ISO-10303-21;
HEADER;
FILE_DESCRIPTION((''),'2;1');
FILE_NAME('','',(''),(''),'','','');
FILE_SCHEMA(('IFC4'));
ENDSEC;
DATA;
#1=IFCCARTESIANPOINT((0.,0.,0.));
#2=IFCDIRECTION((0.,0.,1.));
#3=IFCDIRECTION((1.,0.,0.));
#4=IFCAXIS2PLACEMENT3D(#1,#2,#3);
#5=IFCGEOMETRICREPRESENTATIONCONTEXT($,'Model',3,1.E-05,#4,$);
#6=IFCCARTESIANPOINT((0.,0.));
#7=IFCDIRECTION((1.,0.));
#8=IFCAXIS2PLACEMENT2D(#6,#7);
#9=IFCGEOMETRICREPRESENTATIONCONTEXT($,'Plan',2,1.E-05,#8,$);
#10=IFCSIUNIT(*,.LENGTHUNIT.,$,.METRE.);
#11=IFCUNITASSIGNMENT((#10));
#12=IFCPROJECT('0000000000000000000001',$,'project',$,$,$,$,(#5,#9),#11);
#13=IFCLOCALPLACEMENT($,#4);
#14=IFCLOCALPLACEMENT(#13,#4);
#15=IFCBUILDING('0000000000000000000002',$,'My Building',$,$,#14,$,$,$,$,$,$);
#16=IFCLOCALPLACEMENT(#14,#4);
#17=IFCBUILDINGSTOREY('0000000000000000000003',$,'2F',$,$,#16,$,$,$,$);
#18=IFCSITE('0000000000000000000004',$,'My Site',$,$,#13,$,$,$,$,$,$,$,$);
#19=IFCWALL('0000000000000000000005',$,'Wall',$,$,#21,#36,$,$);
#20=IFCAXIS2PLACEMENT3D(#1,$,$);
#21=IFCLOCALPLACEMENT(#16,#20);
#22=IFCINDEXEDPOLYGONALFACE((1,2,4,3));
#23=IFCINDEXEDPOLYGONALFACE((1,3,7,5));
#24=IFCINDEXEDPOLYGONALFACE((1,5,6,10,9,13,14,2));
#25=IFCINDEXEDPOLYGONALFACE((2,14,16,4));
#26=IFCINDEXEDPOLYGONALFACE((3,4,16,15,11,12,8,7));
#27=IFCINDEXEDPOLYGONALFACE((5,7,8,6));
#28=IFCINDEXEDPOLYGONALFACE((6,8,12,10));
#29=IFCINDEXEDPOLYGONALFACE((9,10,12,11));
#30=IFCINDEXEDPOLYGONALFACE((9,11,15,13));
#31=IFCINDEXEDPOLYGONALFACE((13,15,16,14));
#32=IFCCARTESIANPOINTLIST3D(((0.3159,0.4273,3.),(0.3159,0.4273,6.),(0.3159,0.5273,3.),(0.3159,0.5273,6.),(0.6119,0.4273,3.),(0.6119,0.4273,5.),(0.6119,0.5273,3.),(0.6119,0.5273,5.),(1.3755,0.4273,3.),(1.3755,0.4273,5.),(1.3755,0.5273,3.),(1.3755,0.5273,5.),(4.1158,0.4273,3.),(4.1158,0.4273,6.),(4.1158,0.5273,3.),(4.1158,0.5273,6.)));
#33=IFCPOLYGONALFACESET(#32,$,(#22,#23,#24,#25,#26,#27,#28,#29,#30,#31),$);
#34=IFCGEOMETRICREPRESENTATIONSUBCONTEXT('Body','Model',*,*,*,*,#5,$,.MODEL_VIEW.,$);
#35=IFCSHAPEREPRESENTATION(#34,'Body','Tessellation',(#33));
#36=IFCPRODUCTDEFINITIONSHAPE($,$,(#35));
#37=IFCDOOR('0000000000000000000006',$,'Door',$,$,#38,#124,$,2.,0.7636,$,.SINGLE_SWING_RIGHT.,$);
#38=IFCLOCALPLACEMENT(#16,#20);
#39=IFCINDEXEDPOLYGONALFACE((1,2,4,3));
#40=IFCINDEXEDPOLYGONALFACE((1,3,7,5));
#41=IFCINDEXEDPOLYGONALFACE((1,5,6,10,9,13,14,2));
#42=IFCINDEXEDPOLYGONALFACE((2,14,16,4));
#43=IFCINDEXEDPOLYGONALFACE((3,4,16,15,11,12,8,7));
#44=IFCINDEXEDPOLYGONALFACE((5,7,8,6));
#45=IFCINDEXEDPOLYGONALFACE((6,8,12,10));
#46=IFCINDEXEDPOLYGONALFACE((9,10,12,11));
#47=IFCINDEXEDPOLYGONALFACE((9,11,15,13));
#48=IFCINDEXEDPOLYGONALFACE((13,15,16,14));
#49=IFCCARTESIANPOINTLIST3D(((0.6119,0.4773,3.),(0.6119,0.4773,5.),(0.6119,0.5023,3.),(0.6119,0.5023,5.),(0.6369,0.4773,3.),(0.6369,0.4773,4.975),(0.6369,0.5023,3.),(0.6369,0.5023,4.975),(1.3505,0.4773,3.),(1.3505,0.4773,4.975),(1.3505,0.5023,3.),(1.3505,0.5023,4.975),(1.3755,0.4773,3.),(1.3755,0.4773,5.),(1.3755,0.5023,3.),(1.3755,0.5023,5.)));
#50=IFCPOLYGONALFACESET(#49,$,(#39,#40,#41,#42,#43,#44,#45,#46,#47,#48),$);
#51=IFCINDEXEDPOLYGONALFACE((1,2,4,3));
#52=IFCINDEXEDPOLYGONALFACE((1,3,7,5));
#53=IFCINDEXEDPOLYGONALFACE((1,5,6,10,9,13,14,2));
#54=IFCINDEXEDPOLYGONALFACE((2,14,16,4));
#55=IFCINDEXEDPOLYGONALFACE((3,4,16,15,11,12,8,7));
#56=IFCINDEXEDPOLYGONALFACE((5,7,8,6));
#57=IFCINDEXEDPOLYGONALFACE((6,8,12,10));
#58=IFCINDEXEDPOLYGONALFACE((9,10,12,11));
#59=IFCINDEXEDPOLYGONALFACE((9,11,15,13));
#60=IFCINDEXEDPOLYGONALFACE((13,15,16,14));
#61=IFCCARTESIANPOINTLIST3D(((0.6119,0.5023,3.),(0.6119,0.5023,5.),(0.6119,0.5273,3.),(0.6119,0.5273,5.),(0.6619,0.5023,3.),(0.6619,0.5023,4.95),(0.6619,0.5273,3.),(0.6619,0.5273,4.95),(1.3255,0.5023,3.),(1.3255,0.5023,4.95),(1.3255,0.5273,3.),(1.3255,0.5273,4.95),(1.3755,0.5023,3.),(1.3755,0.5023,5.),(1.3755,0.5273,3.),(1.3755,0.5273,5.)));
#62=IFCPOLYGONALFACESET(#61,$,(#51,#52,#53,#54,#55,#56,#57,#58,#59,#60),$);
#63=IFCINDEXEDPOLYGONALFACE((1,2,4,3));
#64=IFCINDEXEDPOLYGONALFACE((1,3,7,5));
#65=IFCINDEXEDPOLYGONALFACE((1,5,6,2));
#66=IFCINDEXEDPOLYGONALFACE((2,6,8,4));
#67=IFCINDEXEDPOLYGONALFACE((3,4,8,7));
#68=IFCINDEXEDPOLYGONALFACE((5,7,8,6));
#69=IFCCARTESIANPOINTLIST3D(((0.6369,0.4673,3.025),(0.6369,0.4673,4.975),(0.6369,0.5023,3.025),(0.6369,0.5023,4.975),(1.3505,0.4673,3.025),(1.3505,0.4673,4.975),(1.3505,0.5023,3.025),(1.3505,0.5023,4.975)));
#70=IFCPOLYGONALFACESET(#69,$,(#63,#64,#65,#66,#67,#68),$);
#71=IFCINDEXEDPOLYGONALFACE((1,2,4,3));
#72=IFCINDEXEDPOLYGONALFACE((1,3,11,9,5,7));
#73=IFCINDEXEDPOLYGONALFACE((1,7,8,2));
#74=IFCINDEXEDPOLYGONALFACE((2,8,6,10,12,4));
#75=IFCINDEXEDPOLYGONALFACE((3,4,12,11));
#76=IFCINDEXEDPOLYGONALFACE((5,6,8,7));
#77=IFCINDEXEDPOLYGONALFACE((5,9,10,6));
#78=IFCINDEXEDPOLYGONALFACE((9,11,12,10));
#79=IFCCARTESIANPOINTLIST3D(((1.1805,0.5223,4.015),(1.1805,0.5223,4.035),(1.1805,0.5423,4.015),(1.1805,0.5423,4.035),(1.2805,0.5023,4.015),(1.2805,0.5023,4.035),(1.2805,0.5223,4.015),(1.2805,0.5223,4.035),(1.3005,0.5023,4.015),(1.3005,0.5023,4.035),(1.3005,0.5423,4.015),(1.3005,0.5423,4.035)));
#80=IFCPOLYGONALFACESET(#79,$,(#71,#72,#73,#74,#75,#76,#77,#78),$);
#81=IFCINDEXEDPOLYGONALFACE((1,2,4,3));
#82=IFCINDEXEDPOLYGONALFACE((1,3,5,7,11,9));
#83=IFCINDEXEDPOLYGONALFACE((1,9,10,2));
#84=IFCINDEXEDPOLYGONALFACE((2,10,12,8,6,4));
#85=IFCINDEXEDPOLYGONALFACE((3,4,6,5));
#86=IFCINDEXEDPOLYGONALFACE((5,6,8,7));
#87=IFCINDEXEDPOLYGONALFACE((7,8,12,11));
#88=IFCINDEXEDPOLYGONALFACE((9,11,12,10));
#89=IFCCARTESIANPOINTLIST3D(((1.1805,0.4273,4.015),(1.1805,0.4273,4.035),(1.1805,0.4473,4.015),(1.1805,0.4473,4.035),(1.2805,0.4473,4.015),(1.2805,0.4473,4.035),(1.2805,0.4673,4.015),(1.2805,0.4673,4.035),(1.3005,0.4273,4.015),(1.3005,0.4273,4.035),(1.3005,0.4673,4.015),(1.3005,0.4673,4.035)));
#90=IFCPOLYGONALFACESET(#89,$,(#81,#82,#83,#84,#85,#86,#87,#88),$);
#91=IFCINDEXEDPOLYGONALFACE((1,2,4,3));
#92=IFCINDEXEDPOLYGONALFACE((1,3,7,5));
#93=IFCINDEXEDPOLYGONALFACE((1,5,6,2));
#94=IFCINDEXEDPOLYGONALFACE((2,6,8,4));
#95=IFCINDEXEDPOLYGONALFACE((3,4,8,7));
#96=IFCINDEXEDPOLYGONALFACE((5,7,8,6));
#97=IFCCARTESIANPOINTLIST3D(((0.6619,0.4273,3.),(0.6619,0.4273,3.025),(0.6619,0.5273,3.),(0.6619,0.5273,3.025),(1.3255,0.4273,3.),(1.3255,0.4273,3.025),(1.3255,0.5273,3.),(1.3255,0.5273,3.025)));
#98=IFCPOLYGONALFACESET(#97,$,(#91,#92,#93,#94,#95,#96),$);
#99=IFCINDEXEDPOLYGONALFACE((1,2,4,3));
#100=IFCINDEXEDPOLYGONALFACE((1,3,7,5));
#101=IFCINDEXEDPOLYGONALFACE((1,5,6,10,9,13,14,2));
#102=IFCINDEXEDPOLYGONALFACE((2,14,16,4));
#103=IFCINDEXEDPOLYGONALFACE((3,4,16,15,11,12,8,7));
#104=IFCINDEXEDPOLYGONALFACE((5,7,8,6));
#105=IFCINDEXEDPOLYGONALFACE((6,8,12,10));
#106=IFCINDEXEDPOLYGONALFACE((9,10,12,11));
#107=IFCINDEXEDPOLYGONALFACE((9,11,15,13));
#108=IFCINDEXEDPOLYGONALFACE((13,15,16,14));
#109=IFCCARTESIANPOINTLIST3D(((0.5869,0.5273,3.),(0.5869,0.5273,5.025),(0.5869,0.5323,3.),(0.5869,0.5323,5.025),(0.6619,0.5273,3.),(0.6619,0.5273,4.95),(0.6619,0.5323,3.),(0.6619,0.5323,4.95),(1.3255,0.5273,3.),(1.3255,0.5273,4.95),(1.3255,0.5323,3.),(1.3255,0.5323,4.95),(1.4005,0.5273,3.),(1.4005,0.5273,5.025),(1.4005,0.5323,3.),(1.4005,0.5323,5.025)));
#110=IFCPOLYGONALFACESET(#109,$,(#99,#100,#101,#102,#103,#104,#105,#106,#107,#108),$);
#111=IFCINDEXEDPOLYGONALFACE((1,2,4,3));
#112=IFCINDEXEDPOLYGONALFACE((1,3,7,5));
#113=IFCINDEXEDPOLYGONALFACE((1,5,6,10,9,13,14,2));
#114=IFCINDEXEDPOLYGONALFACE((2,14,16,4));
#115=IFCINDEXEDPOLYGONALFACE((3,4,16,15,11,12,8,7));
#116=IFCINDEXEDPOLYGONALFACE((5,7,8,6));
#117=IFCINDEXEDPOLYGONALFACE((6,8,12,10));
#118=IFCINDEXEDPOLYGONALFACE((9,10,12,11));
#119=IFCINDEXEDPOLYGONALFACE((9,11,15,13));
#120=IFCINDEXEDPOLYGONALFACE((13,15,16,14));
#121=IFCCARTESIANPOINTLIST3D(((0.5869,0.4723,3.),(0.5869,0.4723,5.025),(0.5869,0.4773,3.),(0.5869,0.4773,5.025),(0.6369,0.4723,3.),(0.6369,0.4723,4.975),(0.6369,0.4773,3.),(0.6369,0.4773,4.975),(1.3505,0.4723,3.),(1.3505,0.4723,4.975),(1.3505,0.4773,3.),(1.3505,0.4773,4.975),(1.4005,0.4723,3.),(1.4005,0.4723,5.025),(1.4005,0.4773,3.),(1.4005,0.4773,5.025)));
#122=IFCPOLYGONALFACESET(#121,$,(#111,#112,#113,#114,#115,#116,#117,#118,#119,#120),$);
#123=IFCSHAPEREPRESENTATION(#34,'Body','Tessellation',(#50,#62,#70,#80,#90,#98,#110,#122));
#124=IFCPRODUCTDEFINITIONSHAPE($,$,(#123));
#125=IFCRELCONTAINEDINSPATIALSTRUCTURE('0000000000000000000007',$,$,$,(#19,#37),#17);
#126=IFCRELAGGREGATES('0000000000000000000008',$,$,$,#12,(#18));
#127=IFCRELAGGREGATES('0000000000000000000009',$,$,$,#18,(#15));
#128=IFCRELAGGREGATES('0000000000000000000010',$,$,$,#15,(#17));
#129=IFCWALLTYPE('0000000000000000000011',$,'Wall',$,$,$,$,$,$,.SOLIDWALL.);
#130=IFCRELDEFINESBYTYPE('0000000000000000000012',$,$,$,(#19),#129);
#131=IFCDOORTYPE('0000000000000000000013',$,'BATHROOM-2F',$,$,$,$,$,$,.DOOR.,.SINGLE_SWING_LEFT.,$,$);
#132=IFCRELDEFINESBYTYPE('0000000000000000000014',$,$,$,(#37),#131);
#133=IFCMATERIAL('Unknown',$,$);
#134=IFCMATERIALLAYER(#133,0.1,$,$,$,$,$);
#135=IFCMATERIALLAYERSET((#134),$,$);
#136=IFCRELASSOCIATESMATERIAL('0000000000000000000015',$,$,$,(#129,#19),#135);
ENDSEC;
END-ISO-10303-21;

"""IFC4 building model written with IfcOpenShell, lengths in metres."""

from ifc_helpers import new_model, entity, si_unit, frame, origin_with_axes, origin_2d_with_axis, place, context, subcontext, project, spatial, line, indexed_curve, outline, extrude, shape, source, transform, mapped, material, layer, layer_set, layer_usage, type_object, type_shapes, element, fill, save


model = new_model("IFC4")

# Units and contexts
model_context = context("Model", 3, precision=1e-05, world=origin_with_axes())
plan_context = context("Plan", 2, precision=1e-05, world=origin_2d_with_axis())
body_context_1 = subcontext(model_context, "Body", "Model", "MODEL_VIEW")
body_context_2 = subcontext(plan_context, "Body", "Plan", "PLAN_VIEW")
ifc_project = project(units=[si_unit("LENGTHUNIT", "METRE")], contexts=[model_context, plan_context])

# Site, building, storey
site_placement = place(None, origin_with_axes())
site = spatial("IfcSite", under=ifc_project, at=site_placement, Name="My Site")
building_placement = place(site_placement, origin_with_axes())
building = spatial("IfcBuilding", under=site, at=building_placement, Name="My Building")
storey_placement = place(building_placement, origin_with_axes())
storey = spatial("IfcBuildingStorey", under=building, at=storey_placement, Name="2F")

# Shared definitions
ifc_material_1 = material(Name="Unknown")

# Shared definitions
ifc_layer_1 = layer(ifc_material_1, 0.1)
ifc_layer_set_1 = layer_set([ifc_layer_1])
wall_type = type_object("IfcWallType", Name="Wall", PredefinedType="SOLIDWALL", material=ifc_layer_set_1)

# Wall, opening, door
ifc_layer_usage_1 = layer_usage(ifc_layer_set_1, "AXIS2", "POSITIVE", 0.0)
wall_1_placement = place(storey_placement, frame((0.3159, 0.4273, 3.0), z_axis=(0.0, 0.0, 1.0), x_axis=(1.0, 0.0, 0.0)))
wall_1 = element("IfcWall", 1, at=wall_1_placement, inside=storey, type_object=wall_type, material=ifc_layer_usage_1, Name="Wall", context=body_context_1, shape_type="SweptSolid", body=[
    extrude(outline(indexed_curve([(0.0, 0.0), (0.0, 0.1), (3.8, 0.1), (3.8, 0.0)], segments=[line(1, 2, 3, 4, 1)])), origin_with_axes(), (0.0, 0.0, 1.0), 3.0),
])
shared_shape_1 = source(origin_with_axes(), body_context_1, "Body", "SweptSolid", [
    extrude(outline(indexed_curve([(0.0, 0.0), (0.7636, 0.0), (0.7636, 2.0), (0.0, 2.0)], segments=[line(1, 2, 3, 4, 1)])), frame((0.0, -0.6, 0.0), z_axis=(0.0, -1.0, 0.0), x_axis=(1.0, 0.0, 0.0)), (0.0, 0.0, -1.0), 1.2),
])
opening_1_placement = place(wall_1_placement, frame((1.0596, 0.1, 0.0), z_axis=(0.0, 0.0, 1.0), x_axis=(-1.0, 0.0, 0.0)))
opening_1 = element("IfcOpeningElement", 2, at=opening_1_placement, cuts=wall_1, PredefinedType="OPENING", context=body_context_1, shape_type="MappedRepresentation", body=[
    mapped(shared_shape_1, transform((0.0, 0.0, 0.0), x_axis=(1.0, 0.0, 0.0), y_axis=(0.0, 1.0, 0.0), z_axis=(0.0, 0.0, 1.0), scale=1.0)),
])
door_type_1 = type_object("IfcDoorType", Name="BATHROOM-2F", OperationType="SINGLE_SWING_LEFT", PredefinedType="DOOR")
shared_shape_2 = source(origin_with_axes(), body_context_1, "Body", "SweptSolid", [
    extrude(outline(indexed_curve([(0.0, 0.0), (0.0, 2.0), (0.7636, 2.0), (0.7636, 0.0), (0.7386, 0.0), (0.7386, 1.975), (0.025, 1.975), (0.025, 0.0)], segments=[line(1, 2, 3, 4, 5, 6, 7, 8, 1)])), frame((0.0, 0.025, 0.0), z_axis=(0.0, -1.0, 0.0), x_axis=(1.0, 0.0, 0.0)), (0.0, 0.0, -1.0), 0.025),
    extrude(outline(indexed_curve([(0.0, 0.0), (0.0, 2.0), (0.7636, 2.0), (0.7636, 0.0), (0.7136, 0.0), (0.7136, 1.95), (0.05, 1.95), (0.05, 0.0)], segments=[line(1, 2, 3, 4, 5, 6, 7, 8, 1)])), frame((0.0, 0.0, 0.0), z_axis=(0.0, -1.0, 0.0), x_axis=(1.0, 0.0, 0.0)), (0.0, 0.0, -1.0), 0.025),
    extrude(outline(indexed_curve([(0.0, 0.0), (0.7136, 0.0), (0.7136, 0.035), (0.0, 0.035)], segments=[line(1, 2, 3, 4, 1)])), frame((0.025, 0.025, 0.025), z_axis=(0.0, 0.0, 1.0), x_axis=(1.0, 0.0, 0.0)), (0.0, 0.0, 1.0), 1.95),
    extrude(outline(indexed_curve([(0.0, 0.0), (0.0, -0.04), (0.12, -0.04), (0.12, -0.02), (0.02, -0.02), (0.02, 0.0)], segments=[line(1, 2, 3, 4, 5, 6, 1)])), frame((0.075, 0.025, 1.015), z_axis=(0.0, 0.0, 1.0), x_axis=(1.0, 0.0, 0.0)), (0.0, 0.0, 1.0), 0.02),
    extrude(outline(indexed_curve([(0.0, 0.0), (0.0, 0.04), (0.12, 0.04), (0.12, 0.02), (0.02, 0.02), (0.02, 0.0)], segments=[line(1, 2, 3, 4, 5, 6, 1)])), frame((0.075, 0.06, 1.015), z_axis=(0.0, 0.0, 1.0), x_axis=(1.0, 0.0, 0.0)), (0.0, 0.0, 1.0), 0.02),
    extrude(outline(indexed_curve([(0.0, 0.0), (0.6636, 0.0), (0.6636, 0.1), (0.0, 0.1)], segments=[line(1, 2, 3, 4, 1)])), frame((0.05, 0.0, 0.0), z_axis=(0.0, 0.0, 1.0), x_axis=(1.0, 0.0, 0.0)), (0.0, 0.0, 1.0), 0.025),
    extrude(outline(indexed_curve([(0.0, 0.0), (0.0, 2.025), (0.8136, 2.025), (0.8136, 0.0), (0.7386, 0.0), (0.7386, 1.95), (0.075, 1.95), (0.075, 0.0)], segments=[line(1, 2, 3, 4, 5, 6, 7, 8, 1)])), frame((-0.025, -0.005, 0.0), z_axis=(0.0, -1.0, 0.0), x_axis=(1.0, 0.0, 0.0)), (0.0, 0.0, -1.0), 0.005),
    extrude(outline(indexed_curve([(0.0, 0.0), (0.0, 2.025), (0.8136, 2.025), (0.8136, 0.0), (0.7636, 0.0), (0.7636, 1.975), (0.05, 1.975), (0.05, 0.0)], segments=[line(1, 2, 3, 4, 5, 6, 7, 8, 1)])), frame((-0.025, 0.05, 0.0), z_axis=(0.0, -1.0, 0.0), x_axis=(1.0, 0.0, 0.0)), (0.0, 0.0, -1.0), 0.005),
])
shared_shape_3 = source(origin_with_axes(), body_context_2, "Body", "Curve2D", [
    entity("IfcIndexedPolyCurve", entity("IfcCartesianPointList2D", [[0.0, 0.0], [0.0, 0.05], [0.025, 0.05], [0.025, 0.025], [0.05, 0.025], [0.05, 0.0]]), [entity("IfcLineIndex", [1, 2, 3, 4, 5, 6, 1])]),
    entity("IfcIndexedPolyCurve", entity("IfcCartesianPointList2D", [[0.7636, 0.0], [0.7636, 0.05], [0.7386, 0.05], [0.7386, 0.025], [0.7136, 0.025], [0.7136, 0.0]]), [entity("IfcLineIndex", [1, 2, 3, 4, 5, 6, 1])]),
    entity("IfcTrimmedCurve", entity("IfcEllipse", entity("IfcAxis2Placement2D", entity("IfcCartesianPoint", [0.7036, 0.05]), entity("IfcDirection", [1.0, 0.0])), 0.6786, 0.7136), [entity("IfcCartesianPoint", [0.7036, 0.7636])], [entity("IfcCartesianPoint", [0.025, 0.05])], True, "CARTESIAN"),
    entity("IfcIndexedPolyCurve", entity("IfcCartesianPointList2D", [[0.7386, 0.05], [0.7036, 0.05], [0.7036, 0.7636], [0.7386, 0.7636]]), [entity("IfcLineIndex", [1, 2, 3, 4, 1])]),
])
type_shapes(door_type_1, [shared_shape_2, shared_shape_3])
door_1_placement = place(opening_1_placement, frame((0.0, 0.0, 0.0), z_axis=(0.0, 0.0, 1.0), x_axis=(1.0, 0.0, 0.0)))
door_1 = element("IfcDoor", 3, at=door_1_placement, inside=storey, type_object=door_type_1, Name="Door", OperationType="SINGLE_SWING_RIGHT", OverallHeight=2.0, OverallWidth=0.7636, shapes=[
    shape(body_context_1, "Body", "MappedRepresentation", [mapped(shared_shape_2, transform((0.0, 0.0, 0.0), x_axis=(1.0, 0.0, 0.0), y_axis=(0.0, 1.0, 0.0), z_axis=(0.0, 0.0, 1.0), scale=1.0))]),
    shape(body_context_2, "Body", "MappedRepresentation", [mapped(shared_shape_3, transform((0.0, 0.0, 0.0), x_axis=(1.0, 0.0, 0.0), y_axis=(0.0, 1.0, 0.0), z_axis=(0.0, 0.0, 1.0), scale=1.0))]),
])
fill(opening_1, door_1)

save(model, "model.ifc")
